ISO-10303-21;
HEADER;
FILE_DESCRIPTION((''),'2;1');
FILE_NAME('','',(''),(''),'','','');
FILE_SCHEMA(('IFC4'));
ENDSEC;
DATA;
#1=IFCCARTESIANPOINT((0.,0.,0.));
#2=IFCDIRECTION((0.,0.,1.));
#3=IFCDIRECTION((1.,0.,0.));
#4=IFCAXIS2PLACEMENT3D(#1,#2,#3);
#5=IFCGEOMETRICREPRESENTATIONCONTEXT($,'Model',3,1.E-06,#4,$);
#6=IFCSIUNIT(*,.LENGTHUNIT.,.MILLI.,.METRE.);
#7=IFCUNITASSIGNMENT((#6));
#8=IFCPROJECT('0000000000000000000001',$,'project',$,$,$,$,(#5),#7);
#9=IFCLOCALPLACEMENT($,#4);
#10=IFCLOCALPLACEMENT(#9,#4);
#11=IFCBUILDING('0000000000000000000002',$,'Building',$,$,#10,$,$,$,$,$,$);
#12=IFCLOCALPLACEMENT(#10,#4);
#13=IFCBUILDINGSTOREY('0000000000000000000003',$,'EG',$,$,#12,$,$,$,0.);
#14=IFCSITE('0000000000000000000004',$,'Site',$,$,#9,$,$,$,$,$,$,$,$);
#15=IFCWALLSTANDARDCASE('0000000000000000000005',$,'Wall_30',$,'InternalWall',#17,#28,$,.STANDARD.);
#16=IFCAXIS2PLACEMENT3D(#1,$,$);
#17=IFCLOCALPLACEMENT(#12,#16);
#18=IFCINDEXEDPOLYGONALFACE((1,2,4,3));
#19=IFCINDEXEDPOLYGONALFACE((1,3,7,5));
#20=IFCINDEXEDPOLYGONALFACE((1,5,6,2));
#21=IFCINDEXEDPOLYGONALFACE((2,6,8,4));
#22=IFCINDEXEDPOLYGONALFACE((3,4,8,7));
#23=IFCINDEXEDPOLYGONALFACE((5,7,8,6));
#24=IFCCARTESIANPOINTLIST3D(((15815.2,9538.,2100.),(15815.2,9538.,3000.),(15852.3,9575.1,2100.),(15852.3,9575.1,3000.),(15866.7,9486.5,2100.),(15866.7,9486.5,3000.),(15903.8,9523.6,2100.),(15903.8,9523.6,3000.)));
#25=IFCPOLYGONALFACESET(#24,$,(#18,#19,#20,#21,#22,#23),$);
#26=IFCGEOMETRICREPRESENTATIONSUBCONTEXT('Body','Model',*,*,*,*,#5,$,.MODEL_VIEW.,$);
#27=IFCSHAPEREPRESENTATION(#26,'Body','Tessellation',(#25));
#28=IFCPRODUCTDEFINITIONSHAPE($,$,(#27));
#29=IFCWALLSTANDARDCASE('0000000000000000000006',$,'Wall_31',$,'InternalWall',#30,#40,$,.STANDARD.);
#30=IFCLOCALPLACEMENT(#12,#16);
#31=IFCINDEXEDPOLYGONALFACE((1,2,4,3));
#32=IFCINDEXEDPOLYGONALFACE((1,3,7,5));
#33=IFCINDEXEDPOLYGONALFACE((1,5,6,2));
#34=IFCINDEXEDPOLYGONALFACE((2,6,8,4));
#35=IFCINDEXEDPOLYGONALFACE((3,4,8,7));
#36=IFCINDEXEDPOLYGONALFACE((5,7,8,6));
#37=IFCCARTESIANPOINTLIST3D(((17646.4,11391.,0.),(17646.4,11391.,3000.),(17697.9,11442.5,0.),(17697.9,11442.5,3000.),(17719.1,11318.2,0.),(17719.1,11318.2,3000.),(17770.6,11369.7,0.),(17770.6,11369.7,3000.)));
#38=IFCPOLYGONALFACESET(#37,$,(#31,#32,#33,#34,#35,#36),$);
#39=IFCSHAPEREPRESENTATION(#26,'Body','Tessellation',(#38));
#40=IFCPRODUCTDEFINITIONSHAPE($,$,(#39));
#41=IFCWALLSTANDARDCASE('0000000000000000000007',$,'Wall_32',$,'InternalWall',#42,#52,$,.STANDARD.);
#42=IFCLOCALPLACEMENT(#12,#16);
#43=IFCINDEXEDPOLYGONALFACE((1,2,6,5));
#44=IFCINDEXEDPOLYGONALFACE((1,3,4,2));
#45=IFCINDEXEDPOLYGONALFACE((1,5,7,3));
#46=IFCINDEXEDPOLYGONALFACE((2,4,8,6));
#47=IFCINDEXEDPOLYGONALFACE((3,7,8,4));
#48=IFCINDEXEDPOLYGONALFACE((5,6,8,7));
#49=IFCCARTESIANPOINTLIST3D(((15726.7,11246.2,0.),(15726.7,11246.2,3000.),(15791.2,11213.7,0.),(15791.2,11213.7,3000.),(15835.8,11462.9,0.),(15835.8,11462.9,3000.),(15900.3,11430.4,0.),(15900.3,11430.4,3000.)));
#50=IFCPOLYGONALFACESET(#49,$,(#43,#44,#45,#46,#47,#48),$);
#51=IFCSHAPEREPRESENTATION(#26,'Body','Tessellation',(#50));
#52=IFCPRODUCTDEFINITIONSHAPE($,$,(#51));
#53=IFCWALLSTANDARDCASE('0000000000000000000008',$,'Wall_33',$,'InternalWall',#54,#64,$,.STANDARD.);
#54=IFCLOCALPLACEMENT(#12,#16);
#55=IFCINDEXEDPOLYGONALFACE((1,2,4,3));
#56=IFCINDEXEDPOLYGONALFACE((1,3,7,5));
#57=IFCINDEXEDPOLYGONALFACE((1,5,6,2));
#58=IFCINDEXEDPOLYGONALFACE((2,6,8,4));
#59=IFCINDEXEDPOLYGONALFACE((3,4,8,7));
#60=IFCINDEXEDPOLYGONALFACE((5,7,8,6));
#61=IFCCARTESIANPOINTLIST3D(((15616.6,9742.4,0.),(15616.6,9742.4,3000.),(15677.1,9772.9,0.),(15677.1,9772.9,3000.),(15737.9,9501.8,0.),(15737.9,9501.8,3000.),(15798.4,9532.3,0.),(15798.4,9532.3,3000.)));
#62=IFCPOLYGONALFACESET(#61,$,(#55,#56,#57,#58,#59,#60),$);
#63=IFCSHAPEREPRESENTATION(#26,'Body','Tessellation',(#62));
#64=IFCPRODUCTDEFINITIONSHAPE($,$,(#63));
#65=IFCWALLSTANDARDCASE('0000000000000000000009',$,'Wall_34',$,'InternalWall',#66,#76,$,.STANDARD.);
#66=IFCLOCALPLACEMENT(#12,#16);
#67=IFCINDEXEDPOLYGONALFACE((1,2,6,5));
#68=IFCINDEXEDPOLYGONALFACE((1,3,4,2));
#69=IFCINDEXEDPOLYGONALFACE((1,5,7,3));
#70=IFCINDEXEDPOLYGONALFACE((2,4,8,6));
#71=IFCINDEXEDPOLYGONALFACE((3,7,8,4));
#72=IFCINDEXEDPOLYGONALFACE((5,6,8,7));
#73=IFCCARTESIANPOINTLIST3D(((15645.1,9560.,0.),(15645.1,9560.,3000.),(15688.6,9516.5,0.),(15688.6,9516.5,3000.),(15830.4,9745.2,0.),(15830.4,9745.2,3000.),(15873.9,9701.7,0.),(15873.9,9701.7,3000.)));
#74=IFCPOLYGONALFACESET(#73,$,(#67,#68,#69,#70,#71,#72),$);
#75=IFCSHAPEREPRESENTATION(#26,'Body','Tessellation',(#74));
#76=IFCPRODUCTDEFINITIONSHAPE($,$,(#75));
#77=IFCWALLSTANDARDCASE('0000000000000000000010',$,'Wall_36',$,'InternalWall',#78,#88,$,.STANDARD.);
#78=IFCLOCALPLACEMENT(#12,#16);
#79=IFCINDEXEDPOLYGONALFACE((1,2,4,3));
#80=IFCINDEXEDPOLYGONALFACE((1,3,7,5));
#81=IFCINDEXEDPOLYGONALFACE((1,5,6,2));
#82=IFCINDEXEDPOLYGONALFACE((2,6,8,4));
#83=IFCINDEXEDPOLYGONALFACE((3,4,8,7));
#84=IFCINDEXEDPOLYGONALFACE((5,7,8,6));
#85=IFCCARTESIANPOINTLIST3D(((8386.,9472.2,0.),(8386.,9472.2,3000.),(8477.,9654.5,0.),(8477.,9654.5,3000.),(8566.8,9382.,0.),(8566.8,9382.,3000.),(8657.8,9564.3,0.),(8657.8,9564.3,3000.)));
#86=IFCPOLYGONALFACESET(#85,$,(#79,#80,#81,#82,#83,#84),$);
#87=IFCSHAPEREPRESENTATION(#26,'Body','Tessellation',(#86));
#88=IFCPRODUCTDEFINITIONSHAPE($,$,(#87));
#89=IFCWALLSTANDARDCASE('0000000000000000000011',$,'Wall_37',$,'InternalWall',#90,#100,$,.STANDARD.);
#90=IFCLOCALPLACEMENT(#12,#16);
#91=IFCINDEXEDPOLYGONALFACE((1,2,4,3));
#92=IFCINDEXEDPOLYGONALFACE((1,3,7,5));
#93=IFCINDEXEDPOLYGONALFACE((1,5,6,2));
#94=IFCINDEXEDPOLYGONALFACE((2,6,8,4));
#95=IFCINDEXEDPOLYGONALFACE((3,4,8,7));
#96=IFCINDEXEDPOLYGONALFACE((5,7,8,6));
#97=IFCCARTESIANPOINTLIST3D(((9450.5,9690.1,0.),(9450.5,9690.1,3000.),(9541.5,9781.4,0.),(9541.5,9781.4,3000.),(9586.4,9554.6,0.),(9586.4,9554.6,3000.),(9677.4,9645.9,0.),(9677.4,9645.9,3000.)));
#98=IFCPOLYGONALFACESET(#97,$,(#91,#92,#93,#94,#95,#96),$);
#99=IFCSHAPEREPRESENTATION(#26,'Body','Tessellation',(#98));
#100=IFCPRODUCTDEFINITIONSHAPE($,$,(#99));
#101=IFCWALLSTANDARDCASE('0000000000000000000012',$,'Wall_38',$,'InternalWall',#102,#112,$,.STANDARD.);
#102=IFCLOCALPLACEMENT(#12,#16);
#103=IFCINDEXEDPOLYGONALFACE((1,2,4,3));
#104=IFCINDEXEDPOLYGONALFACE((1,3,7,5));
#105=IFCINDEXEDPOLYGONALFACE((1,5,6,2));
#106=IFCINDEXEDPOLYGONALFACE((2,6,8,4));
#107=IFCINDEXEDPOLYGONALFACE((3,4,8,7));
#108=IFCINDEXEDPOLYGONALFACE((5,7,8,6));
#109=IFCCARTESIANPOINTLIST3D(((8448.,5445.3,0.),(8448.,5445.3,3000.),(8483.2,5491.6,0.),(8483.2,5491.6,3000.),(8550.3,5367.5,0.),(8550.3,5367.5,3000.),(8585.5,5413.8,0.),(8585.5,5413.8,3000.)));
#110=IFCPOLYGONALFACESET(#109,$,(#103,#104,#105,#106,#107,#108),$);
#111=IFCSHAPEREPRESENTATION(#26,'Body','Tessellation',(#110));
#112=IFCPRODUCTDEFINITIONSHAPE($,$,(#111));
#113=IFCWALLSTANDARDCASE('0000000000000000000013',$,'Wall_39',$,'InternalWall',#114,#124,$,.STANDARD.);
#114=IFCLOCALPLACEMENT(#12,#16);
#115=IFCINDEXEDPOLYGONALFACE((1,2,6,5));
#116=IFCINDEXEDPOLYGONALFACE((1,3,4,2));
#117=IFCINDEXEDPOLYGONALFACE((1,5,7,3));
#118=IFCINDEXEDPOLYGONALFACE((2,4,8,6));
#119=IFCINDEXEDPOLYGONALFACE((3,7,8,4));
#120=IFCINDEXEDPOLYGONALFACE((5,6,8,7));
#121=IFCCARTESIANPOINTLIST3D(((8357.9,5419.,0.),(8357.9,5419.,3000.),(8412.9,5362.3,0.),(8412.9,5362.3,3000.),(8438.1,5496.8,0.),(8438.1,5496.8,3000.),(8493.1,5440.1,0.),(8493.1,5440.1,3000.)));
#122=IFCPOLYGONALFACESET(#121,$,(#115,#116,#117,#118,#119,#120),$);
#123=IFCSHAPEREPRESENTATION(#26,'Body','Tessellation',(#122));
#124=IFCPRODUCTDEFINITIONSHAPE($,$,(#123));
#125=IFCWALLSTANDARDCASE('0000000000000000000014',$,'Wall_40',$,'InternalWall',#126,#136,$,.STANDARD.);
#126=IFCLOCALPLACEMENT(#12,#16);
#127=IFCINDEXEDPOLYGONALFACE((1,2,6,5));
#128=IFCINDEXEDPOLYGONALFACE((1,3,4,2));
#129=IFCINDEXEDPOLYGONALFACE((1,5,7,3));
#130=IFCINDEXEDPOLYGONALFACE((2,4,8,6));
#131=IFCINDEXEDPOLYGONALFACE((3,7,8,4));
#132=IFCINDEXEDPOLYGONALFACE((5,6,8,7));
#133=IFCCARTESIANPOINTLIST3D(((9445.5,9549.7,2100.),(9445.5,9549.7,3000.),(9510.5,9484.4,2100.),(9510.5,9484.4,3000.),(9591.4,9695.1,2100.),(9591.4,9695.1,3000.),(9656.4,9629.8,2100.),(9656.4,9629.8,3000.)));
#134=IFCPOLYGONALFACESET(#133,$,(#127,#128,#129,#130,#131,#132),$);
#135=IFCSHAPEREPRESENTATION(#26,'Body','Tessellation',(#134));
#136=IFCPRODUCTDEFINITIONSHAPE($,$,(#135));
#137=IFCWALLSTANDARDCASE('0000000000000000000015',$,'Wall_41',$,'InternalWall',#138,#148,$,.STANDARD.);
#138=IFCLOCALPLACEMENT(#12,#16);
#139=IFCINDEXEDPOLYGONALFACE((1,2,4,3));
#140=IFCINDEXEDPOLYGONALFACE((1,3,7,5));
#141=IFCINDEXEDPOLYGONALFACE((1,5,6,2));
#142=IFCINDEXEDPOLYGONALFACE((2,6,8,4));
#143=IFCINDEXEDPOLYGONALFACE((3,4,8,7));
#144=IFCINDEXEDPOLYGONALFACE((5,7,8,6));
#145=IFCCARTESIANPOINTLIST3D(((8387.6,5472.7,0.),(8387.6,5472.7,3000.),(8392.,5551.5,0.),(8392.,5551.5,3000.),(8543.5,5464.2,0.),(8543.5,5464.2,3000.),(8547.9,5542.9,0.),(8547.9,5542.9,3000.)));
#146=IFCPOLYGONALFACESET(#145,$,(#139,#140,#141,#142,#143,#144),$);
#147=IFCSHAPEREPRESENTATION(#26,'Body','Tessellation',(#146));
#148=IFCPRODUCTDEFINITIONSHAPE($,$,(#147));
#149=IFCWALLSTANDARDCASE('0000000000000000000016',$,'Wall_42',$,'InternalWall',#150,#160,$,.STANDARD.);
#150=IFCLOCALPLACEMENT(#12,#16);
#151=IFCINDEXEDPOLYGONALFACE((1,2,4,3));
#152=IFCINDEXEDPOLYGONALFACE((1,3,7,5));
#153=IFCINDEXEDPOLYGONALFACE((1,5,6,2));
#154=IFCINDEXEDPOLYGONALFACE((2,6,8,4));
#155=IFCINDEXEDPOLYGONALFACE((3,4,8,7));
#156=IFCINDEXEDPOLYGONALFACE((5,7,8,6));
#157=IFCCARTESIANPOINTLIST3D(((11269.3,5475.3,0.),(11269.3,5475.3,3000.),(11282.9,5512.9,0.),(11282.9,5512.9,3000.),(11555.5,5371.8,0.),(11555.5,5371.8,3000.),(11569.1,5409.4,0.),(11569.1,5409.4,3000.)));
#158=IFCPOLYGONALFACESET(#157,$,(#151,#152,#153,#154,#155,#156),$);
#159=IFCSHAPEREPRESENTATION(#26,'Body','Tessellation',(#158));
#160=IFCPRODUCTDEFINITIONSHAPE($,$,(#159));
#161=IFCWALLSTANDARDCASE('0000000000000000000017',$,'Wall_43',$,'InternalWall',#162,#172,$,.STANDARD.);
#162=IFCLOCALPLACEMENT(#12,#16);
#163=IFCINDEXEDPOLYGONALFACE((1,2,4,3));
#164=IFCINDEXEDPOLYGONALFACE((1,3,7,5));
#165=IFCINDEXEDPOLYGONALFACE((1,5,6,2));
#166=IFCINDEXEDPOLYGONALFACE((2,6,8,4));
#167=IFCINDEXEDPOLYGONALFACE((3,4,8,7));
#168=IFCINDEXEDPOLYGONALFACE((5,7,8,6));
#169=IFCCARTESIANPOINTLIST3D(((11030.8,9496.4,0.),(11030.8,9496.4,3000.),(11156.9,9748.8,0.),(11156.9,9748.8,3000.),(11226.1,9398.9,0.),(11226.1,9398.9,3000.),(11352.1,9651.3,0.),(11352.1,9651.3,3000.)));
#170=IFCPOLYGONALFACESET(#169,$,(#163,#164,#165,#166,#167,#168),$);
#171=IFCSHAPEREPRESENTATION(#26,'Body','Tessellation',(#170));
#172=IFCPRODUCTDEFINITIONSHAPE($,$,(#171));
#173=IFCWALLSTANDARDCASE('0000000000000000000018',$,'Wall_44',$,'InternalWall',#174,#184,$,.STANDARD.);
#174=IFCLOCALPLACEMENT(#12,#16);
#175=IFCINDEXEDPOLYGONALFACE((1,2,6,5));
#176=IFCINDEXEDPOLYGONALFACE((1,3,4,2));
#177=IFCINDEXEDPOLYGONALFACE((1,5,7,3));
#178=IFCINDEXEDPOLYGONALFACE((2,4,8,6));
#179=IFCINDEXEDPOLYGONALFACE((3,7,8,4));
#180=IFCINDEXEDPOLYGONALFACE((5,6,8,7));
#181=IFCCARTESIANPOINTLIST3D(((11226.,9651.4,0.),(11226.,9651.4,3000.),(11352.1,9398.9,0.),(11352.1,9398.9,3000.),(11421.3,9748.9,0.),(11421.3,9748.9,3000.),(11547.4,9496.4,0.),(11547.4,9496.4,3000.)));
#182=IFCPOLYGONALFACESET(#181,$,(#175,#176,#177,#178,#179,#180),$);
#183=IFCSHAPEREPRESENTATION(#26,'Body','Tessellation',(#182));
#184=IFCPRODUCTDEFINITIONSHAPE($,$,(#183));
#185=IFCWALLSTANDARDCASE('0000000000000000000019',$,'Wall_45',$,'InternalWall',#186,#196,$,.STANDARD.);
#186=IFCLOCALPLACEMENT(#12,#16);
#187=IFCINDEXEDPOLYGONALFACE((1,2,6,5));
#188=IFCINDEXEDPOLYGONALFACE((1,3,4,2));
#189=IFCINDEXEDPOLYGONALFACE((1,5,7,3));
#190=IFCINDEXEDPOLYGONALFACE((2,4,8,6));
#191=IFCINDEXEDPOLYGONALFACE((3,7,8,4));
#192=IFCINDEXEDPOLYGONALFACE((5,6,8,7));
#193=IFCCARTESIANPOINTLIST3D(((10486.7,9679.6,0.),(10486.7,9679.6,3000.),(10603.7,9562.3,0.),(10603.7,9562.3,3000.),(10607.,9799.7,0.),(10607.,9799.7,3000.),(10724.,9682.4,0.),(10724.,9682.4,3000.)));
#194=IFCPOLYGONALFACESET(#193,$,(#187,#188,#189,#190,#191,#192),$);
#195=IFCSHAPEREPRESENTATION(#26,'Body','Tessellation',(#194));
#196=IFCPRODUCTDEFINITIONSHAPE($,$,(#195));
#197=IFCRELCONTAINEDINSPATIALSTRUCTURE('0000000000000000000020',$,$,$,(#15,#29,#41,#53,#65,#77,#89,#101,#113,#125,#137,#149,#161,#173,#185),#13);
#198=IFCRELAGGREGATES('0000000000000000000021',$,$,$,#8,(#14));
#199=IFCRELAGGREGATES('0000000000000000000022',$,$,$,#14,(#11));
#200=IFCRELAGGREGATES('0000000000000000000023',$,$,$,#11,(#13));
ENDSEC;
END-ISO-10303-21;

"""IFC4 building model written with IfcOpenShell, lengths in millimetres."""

from ifc_helpers import new_model, si_unit, frame, origin_with_axes, place, context, subcontext, project, spatial, rectangle, extrude, element, save


model = new_model("IFC4")

# Units and contexts
model_context = context("Model", 3, precision=1e-06, world=origin_with_axes())
body_context = subcontext(model_context, "Body", "Model", "MODEL_VIEW")
ifc_project = project(units=[si_unit("LENGTHUNIT", "METRE", prefix="MILLI")], contexts=[model_context])

# Site, building, storey
site_placement = place(None, origin_with_axes())
site = spatial("IfcSite", under=ifc_project, at=site_placement, Name="Site")
building_placement = place(site_placement, origin_with_axes())
building = spatial("IfcBuilding", under=site, at=building_placement, Name="Building")
storey_placement = place(building_placement, origin_with_axes())
storey = spatial("IfcBuildingStorey", under=building, at=storey_placement, Name="EG", Elevation=0.0)

# Wall, opening
wall_1_placement = place(storey_placement, origin_with_axes())
wall_1 = element("IfcWallStandardCase", 1, at=wall_1_placement, inside=storey, Name="Wall_30", ObjectType="InternalWall", PredefinedType="STANDARD", context=body_context, shape_type="SweptSolid", body=[
    extrude(rectangle(XDim=72.8, YDim=52.5), frame((15859.5, 9530.8, 0.0), z_axis=(0.0, 0.0, 1.0), x_axis=(0.707107, -0.707107, 0.0)), (0.0, 0.0, 1.0), 3000.0),
])
opening_1_placement = place(wall_1_placement, origin_with_axes())
element("IfcOpeningElement", 2, at=opening_1_placement, inside=storey, cuts=wall_1, context=body_context, shape_type="SweptSolid", body=[
    extrude(rectangle(XDim=450.0, YDim=52.5), frame((15859.5, 9530.8, 0.0), z_axis=(0.0, 0.0, 1.0), x_axis=(0.707107, -0.707107, 0.0)), (0.0, 0.0, 1.0), 2100.0),
])

# Walls
wall_2_placement = place(storey_placement, origin_with_axes())
element("IfcWallStandardCase", 3, at=wall_2_placement, inside=storey, Name="Wall_31", ObjectType="InternalWall", PredefinedType="STANDARD", context=body_context, shape_type="SweptSolid", body=[
    extrude(rectangle(XDim=72.8, YDim=102.9), frame((17708.5, 11380.3, 0.0), z_axis=(0.0, 0.0, 1.0), x_axis=(-0.707107, -0.707107, 0.0)), (0.0, 0.0, 1.0), 3000.0),
])
wall_3_placement = place(storey_placement, origin_with_axes())
element("IfcWallStandardCase", 4, at=wall_3_placement, inside=storey, Name="Wall_32", ObjectType="InternalWall", PredefinedType="STANDARD", context=body_context, shape_type="SweptSolid", body=[
    extrude(rectangle(XDim=72.2, YDim=242.7), frame((15813.5, 11338.3, 0.0), z_axis=(0.0, 0.0, 1.0), x_axis=(0.893038, -0.449981, 0.0)), (0.0, 0.0, 1.0), 3000.0),
])
wall_4_placement = place(storey_placement, origin_with_axes())
element("IfcWallStandardCase", 5, at=wall_4_placement, inside=storey, Name="Wall_33", ObjectType="InternalWall", PredefinedType="STANDARD", context=body_context, shape_type="SweptSolid", body=[
    extrude(rectangle(XDim=67.8, YDim=269.4), frame((15707.5, 9637.3, 0.0), z_axis=(0.0, 0.0, 1.0), x_axis=(0.892946, 0.450163, 0.0)), (0.0, 0.0, 1.0), 3000.0),
])
wall_5_placement = place(storey_placement, origin_with_axes())
element("IfcWallStandardCase", 6, at=wall_5_placement, inside=storey, Name="Wall_34", ObjectType="InternalWall", PredefinedType="STANDARD", context=body_context, shape_type="SweptSolid", body=[
    extrude(rectangle(XDim=61.5, YDim=261.9), frame((15759.5, 9630.8, 0.0), z_axis=(0.0, 0.0, 1.0), x_axis=(0.707107, -0.707107, 0.0)), (0.0, 0.0, 1.0), 3000.0),
])

# Walls
wall_6_placement = place(storey_placement, origin_with_axes())
element("IfcWallStandardCase", 7, at=wall_6_placement, inside=storey, Name="Wall_36", ObjectType="InternalWall", PredefinedType="STANDARD", context=body_context, shape_type="SweptSolid", body=[
    extrude(rectangle(XDim=203.7, YDim=202.0), frame((8521.9, 9518.3, 0.0), z_axis=(0.0, 0.0, 1.0), x_axis=(-0.446723, -0.894673, 0.0)), (0.0, 0.0, 1.0), 3000.0),
])
wall_7_placement = place(storey_placement, origin_with_axes())
element("IfcWallStandardCase", 8, at=wall_7_placement, inside=storey, Name="Wall_37", ObjectType="InternalWall", PredefinedType="STANDARD", context=body_context, shape_type="SweptSolid", body=[
    extrude(rectangle(XDim=128.9, YDim=191.9), frame((9563.9, 9668.0, 0.0), z_axis=(0.0, 0.0, 1.0), x_axis=(0.706136, 0.708076, 0.0)), (0.0, 0.0, 1.0), 3000.0),
])
wall_8_placement = place(storey_placement, origin_with_axes())
element("IfcWallStandardCase", 9, at=wall_8_placement, inside=storey, Name="Wall_38", ObjectType="InternalWall", PredefinedType="STANDARD", context=body_context, shape_type="SweptSolid", body=[
    extrude(rectangle(XDim=128.6, YDim=58.2), frame((8516.8, 5429.5, 0.0), z_axis=(0.0, 0.0, 1.0), x_axis=(0.795985, -0.605317, 0.0)), (0.0, 0.0, 1.0), 3000.0),
])
wall_9_placement = place(storey_placement, origin_with_axes())
element("IfcWallStandardCase", 10, at=wall_9_placement, inside=storey, Name="Wall_39", ObjectType="InternalWall", PredefinedType="STANDARD", context=body_context, shape_type="SweptSolid", body=[
    extrude(rectangle(XDim=111.7, YDim=79.0), frame((8425.5, 5429.5, 0.0), z_axis=(0.0, 0.0, 1.0), x_axis=(-0.717528, -0.69653, 0.0)), (0.0, 0.0, 1.0), 3000.0),
])

# Wall, opening
wall_10_placement = place(storey_placement, origin_with_axes())
wall_10 = element("IfcWallStandardCase", 11, at=wall_10_placement, inside=storey, Name="Wall_40", ObjectType="InternalWall", PredefinedType="STANDARD", context=body_context, shape_type="SweptSolid", body=[
    extrude(rectangle(XDim=92.1, YDim=206.0), frame((9550.9, 9589.8, 0.0), z_axis=(0.0, 0.0, 1.0), x_axis=(0.705748, -0.708463, 0.0)), (0.0, 0.0, 1.0), 3000.0),
])
opening_2_placement = place(wall_10_placement, origin_with_axes())
element("IfcOpeningElement", 12, at=opening_2_placement, inside=storey, cuts=wall_10, context=body_context, shape_type="SweptSolid", body=[
    extrude(rectangle(XDim=450.0, YDim=206.0), frame((9550.9, 9589.8, 0.0), z_axis=(0.0, 0.0, 1.0), x_axis=(0.705748, -0.708463, 0.0)), (0.0, 0.0, 1.0), 2100.0),
])

# Walls
wall_11_placement = place(storey_placement, origin_with_axes())
element("IfcWallStandardCase", 13, at=wall_11_placement, inside=storey, Name="Wall_41", ObjectType="InternalWall", PredefinedType="STANDARD", context=body_context, shape_type="SweptSolid", body=[
    extrude(rectangle(XDim=78.8, YDim=156.1), frame((8467.8, 5507.8, 0.0), z_axis=(0.0, 0.0, 1.0), x_axis=(-0.054966, -0.998488, 0.0)), (0.0, 0.0, 1.0), 3000.0),
])
wall_12_placement = place(storey_placement, origin_with_axes())
element("IfcWallStandardCase", 14, at=wall_12_placement, inside=storey, Name="Wall_42", ObjectType="InternalWall", PredefinedType="STANDARD", context=body_context, shape_type="SweptSolid", body=[
    extrude(rectangle(XDim=304.4, YDim=40.0), frame((11419.2, 5442.4, 0.0), z_axis=(0.0, 0.0, 1.0), x_axis=(-0.940415, 0.340028, 0.0)), (0.0, 0.0, 1.0), 3000.0),
])
wall_13_placement = place(storey_placement, origin_with_axes())
element("IfcWallStandardCase", 15, at=wall_13_placement, inside=storey, Name="Wall_43", ObjectType="InternalWall", PredefinedType="STANDARD", context=body_context, shape_type="SweptSolid", body=[
    extrude(rectangle(XDim=218.2, YDim=282.1), frame((11191.5, 9573.9, 0.0), z_axis=(0.0, 0.0, 1.0), x_axis=(0.894656, -0.446755, 0.0)), (0.0, 0.0, 1.0), 3000.0),
])
wall_14_placement = place(storey_placement, origin_with_axes())
element("IfcWallStandardCase", 16, at=wall_14_placement, inside=storey, Name="Wall_44", ObjectType="InternalWall", PredefinedType="STANDARD", context=body_context, shape_type="SweptSolid", body=[
    extrude(rectangle(XDim=218.2, YDim=282.3), frame((11386.7, 9573.9, 0.0), z_axis=(0.0, 0.0, 1.0), x_axis=(0.894656, 0.446755, 0.0)), (0.0, 0.0, 1.0), 3000.0),
])
wall_15_placement = place(storey_placement, origin_with_axes())
element("IfcWallStandardCase", 17, at=wall_15_placement, inside=storey, Name="Wall_45", ObjectType="InternalWall", PredefinedType="STANDARD", context=body_context, shape_type="SweptSolid", body=[
    extrude(rectangle(XDim=165.6, YDim=170.0), frame((10605.3, 9681.0, 0.0), z_axis=(0.0, 0.0, 1.0), x_axis=(-0.706352, 0.707861, 0.0)), (0.0, 0.0, 1.0), 3000.0),
])

save(model, "model.ifc")
